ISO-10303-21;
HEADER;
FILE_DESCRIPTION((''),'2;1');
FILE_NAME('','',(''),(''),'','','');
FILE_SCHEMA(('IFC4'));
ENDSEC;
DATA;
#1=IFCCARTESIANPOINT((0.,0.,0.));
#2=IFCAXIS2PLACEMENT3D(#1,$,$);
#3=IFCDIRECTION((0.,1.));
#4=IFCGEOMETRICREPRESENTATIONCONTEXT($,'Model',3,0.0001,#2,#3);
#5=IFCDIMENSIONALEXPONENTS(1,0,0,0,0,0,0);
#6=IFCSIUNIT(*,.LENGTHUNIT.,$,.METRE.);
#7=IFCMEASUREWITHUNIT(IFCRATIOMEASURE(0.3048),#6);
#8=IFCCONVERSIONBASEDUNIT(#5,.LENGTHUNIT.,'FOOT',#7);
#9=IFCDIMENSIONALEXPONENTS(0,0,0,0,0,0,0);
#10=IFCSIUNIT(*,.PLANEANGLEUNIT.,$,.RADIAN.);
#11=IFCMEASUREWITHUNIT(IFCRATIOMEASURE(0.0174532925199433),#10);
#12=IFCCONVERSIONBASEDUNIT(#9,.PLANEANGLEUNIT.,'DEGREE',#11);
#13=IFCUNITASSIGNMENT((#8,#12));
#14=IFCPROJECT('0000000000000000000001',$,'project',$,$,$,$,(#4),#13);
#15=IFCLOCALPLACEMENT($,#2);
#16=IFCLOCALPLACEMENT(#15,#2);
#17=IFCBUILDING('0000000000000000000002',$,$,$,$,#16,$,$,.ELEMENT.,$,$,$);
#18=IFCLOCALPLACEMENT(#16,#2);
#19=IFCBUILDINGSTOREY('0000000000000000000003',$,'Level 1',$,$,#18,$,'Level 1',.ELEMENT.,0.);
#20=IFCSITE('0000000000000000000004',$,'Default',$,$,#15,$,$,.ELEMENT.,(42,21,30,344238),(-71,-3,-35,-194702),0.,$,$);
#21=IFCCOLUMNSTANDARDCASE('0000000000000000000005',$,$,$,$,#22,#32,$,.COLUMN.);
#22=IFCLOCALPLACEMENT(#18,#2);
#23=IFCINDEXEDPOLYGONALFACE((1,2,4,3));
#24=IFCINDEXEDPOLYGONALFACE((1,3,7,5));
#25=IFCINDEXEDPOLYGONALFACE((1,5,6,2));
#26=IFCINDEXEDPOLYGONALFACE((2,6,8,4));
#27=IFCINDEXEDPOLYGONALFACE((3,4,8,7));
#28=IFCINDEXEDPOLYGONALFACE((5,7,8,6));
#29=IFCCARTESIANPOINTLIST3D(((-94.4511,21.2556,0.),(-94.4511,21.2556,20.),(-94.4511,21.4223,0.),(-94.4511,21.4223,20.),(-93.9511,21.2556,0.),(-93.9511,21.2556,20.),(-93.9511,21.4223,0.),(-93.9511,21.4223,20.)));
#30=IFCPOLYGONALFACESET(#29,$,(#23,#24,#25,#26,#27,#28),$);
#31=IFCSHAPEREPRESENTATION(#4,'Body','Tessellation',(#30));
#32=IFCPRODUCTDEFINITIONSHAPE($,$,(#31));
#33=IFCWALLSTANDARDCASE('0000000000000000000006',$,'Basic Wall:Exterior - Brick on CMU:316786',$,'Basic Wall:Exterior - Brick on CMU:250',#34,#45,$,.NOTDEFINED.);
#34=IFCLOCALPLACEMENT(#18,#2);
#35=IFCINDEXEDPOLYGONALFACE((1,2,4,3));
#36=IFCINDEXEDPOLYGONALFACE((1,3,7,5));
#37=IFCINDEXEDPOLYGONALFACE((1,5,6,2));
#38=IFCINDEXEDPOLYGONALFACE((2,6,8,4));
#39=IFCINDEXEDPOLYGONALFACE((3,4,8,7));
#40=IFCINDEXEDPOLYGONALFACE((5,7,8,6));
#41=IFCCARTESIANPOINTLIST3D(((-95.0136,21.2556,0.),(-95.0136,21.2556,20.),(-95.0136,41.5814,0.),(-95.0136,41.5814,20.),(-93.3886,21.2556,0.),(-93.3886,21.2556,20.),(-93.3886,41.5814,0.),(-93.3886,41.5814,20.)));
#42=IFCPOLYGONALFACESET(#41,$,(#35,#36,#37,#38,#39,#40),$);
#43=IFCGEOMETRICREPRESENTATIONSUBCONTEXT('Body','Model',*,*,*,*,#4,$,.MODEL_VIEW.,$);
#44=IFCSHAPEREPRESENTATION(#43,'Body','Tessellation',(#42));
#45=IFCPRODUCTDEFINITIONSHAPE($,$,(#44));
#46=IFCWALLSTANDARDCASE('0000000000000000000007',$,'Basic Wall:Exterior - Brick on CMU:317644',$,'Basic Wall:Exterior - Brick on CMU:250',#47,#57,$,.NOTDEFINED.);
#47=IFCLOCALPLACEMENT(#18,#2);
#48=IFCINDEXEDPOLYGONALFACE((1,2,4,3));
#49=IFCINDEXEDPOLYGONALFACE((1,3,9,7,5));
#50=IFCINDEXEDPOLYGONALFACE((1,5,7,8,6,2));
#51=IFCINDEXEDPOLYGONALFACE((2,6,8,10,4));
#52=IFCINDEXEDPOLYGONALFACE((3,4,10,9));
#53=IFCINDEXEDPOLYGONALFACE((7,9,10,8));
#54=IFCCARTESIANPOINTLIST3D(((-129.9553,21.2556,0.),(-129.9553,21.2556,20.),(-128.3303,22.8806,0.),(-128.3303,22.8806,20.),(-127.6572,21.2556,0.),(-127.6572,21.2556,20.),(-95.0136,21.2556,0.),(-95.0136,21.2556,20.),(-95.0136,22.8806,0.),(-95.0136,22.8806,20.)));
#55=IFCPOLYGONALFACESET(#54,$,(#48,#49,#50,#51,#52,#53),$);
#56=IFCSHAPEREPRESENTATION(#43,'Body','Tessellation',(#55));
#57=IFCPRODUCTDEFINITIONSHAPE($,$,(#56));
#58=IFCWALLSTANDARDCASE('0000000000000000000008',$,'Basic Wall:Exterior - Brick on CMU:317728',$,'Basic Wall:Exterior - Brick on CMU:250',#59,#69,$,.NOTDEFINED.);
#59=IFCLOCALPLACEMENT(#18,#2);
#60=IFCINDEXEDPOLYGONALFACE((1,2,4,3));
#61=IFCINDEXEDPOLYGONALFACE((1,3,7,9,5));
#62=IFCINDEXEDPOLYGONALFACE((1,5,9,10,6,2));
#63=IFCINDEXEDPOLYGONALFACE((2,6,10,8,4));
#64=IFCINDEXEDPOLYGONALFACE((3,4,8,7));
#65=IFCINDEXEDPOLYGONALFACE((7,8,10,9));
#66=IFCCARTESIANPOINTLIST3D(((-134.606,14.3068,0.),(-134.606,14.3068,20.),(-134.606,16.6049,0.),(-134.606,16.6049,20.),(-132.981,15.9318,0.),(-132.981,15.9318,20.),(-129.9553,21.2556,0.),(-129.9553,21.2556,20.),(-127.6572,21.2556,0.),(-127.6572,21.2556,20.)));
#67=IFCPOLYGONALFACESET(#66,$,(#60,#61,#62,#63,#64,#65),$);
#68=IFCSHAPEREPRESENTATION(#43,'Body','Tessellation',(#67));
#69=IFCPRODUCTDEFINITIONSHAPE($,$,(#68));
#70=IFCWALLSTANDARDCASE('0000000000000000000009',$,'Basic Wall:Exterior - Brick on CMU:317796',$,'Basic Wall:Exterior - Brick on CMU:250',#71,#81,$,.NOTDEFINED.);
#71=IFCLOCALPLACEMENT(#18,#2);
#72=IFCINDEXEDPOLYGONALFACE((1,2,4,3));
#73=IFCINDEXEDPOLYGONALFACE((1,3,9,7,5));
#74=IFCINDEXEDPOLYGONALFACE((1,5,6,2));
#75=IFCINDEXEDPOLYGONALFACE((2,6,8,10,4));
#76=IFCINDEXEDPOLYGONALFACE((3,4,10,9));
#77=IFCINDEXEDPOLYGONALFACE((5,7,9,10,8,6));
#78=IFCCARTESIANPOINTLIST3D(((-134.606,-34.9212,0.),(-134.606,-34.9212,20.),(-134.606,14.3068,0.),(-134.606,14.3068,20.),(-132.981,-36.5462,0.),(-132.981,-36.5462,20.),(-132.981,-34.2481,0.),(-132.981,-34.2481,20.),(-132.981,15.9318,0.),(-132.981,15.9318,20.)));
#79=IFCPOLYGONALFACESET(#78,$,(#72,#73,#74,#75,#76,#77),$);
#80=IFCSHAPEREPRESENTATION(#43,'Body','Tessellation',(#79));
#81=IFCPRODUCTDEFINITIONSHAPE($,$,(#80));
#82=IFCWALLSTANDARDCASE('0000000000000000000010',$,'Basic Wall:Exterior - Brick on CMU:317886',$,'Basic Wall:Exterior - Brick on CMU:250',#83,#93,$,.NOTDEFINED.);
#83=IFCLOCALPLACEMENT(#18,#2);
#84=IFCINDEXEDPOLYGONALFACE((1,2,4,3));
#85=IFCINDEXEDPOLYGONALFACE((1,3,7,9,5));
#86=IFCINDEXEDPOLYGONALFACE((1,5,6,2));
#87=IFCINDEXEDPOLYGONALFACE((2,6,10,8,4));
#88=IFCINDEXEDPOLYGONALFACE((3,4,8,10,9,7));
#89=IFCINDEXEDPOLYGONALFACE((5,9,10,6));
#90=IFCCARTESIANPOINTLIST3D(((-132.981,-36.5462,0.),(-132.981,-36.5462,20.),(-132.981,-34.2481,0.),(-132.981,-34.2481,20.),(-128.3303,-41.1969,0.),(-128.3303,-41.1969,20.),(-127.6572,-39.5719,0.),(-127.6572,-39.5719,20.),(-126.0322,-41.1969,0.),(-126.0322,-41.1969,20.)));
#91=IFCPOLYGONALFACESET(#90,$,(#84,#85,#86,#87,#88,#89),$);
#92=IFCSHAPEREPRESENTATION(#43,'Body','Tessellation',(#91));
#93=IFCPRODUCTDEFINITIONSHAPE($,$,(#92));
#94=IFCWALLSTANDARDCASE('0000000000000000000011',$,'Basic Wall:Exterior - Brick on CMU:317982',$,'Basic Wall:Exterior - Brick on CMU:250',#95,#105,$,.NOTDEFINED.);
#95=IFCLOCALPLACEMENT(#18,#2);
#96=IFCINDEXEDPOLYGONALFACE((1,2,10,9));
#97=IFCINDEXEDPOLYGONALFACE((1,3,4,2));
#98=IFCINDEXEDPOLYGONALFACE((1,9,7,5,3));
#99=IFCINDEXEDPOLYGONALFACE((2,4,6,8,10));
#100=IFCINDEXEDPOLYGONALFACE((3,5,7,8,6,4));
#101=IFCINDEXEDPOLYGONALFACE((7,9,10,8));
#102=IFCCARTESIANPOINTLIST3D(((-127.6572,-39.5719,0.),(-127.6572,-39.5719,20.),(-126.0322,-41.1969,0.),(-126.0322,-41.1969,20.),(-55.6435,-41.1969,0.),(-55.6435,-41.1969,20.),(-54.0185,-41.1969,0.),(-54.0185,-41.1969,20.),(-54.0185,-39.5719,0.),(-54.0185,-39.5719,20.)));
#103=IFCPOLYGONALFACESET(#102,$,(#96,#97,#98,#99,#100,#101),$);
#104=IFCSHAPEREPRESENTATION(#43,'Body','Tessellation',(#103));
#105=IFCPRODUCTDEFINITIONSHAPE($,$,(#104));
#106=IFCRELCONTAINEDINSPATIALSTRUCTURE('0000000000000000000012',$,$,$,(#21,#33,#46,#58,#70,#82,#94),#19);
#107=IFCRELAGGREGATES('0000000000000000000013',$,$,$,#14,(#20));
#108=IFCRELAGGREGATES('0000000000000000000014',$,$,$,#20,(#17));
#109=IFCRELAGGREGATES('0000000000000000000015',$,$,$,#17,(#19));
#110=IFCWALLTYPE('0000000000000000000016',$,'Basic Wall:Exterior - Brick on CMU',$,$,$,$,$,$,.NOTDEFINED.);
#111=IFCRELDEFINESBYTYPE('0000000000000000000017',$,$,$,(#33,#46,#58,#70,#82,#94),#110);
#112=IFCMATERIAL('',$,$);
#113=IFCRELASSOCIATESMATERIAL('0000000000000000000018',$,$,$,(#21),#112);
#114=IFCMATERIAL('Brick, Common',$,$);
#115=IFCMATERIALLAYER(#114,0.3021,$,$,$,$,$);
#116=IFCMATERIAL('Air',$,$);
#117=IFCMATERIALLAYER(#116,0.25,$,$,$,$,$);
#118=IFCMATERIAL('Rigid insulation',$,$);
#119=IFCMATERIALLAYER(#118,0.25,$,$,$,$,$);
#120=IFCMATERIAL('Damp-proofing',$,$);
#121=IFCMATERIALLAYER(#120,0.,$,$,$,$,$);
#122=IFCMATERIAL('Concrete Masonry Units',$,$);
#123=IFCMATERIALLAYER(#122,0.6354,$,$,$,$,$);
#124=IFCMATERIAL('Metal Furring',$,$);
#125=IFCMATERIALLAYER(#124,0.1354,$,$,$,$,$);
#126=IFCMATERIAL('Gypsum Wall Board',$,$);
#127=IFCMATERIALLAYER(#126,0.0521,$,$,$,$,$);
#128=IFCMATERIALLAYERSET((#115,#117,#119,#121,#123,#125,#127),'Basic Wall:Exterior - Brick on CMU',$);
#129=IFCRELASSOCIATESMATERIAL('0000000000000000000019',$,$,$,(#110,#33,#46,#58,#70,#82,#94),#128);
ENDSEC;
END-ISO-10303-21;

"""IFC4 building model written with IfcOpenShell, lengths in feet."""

from ifc_helpers import new_model, entity, si_unit, converted_unit, direction, frame, frame_2d, origin, place, context, subcontext, project, spatial, polyline, rectangle, outline, extrude, material, layer, layer_set, layer_usage, type_object, element, save


model = new_model("IFC4")

# Units and contexts
model_context = context("Model", 3, precision=0.0001, world=origin(), true_north=direction((0.0, 1.0)))
body_context = subcontext(model_context, "Body", "Model", "MODEL_VIEW")
ifc_project = project(units=[converted_unit("LENGTHUNIT", "FOOT", entity("IfcRatioMeasure", 0.3048), si_unit("LENGTHUNIT", "METRE"), dimensions=[1, 0, 0, 0, 0, 0, 0]), converted_unit("PLANEANGLEUNIT", "DEGREE", entity("IfcRatioMeasure", 0.0174532925199433), si_unit("PLANEANGLEUNIT", "RADIAN"), dimensions=[0, 0, 0, 0, 0, 0, 0])], contexts=[model_context])

# Site, building, storey
site_placement = place(None, origin())
site = spatial("IfcSite", under=ifc_project, at=site_placement, Name="Default", CompositionType="ELEMENT", RefLatitude=(42, 21, 30, 344238), RefLongitude=(-71, -3, -35, -194702), RefElevation=0.0)
building_placement = place(site_placement, origin())
building = spatial("IfcBuilding", under=site, at=building_placement, CompositionType="ELEMENT")
storey_placement = place(building_placement, origin())
storey = spatial("IfcBuildingStorey", under=building, at=storey_placement, Name="Level 1", LongName="Level 1", CompositionType="ELEMENT", Elevation=0.0)

# Column
ifc_material_1 = material(Name="")
wall_1_placement = place(storey_placement, frame((-94.2011, 21.2556, 0.0), z_axis=(0.0, 0.0, 1.0), x_axis=(0.0, 1.0, 0.0)))
for number, where, z_axis, x_axis in (
    (1, (0.0833, 0.0, 0.0), (0.0, 0.0, 1.0), (1.0, 0.0, 0.0)),
):
    element("IfcColumnStandardCase", number, at=place(wall_1_placement, frame(where, z_axis=z_axis, x_axis=x_axis)), inside=storey, material=ifc_material_1, PredefinedType="COLUMN", context=model_context, shape_type="SweptSolid", body=[
        extrude(rectangle(XDim=0.1667, YDim=0.5), origin(), (0.0, 0.0, 1.0), 20.0),
    ])

# Walls
ifc_material_2 = material(Name="Brick, Common")
ifc_layer_1 = layer(ifc_material_2, 0.3021)
ifc_material_3 = material(Name="Air")
ifc_layer_2 = layer(ifc_material_3, 0.25)
ifc_material_4 = material(Name="Rigid insulation")
ifc_layer_3 = layer(ifc_material_4, 0.25)
ifc_material_5 = material(Name="Damp-proofing")
ifc_layer_4 = layer(ifc_material_5, 0.0)
ifc_material_6 = material(Name="Concrete Masonry Units")
ifc_layer_5 = layer(ifc_material_6, 0.6354)
ifc_material_7 = material(Name="Metal Furring")
ifc_layer_6 = layer(ifc_material_7, 0.1354)
ifc_material_8 = material(Name="Gypsum Wall Board")
ifc_layer_7 = layer(ifc_material_8, 0.0521)
ifc_layer_set = layer_set([ifc_layer_1, ifc_layer_2, ifc_layer_3, ifc_layer_4, ifc_layer_5, ifc_layer_6, ifc_layer_7], Name="Basic Wall:Exterior - Brick on CMU")
ifc_layer_usage_1 = layer_usage(ifc_layer_set, "AXIS2", "NEGATIVE", 0.8125)
wall_type = type_object("IfcWallType", Name="Basic Wall:Exterior - Brick on CMU", PredefinedType="NOTDEFINED", material=ifc_layer_set)
element("IfcWallStandardCase", 2, at=wall_1_placement, inside=storey, type_object=wall_type, material=ifc_layer_usage_1, Name="Basic Wall:Exterior - Brick on CMU:316786", ObjectType="Basic Wall:Exterior - Brick on CMU:250", PredefinedType="NOTDEFINED", context=body_context, shape_type="SweptSolid", body=[
    extrude(rectangle(XDim=20.3258, YDim=1.625, at=frame_2d((10.1629, 0.0), x_axis=(-1.0, 0.0))), origin(), (0.0, 0.0, 1.0), 20.0),
])
ifc_layer_usage_2 = layer_usage(ifc_layer_set, "AXIS2", "NEGATIVE", 0.8125)
wall_2_placement = place(storey_placement, frame((-95.0136, 22.0681, 0.0), z_axis=(0.0, 0.0, 1.0), x_axis=(-1.0, 0.0, 0.0)))
element("IfcWallStandardCase", 3, at=wall_2_placement, inside=storey, type_object=wall_type, material=ifc_layer_usage_2, Name="Basic Wall:Exterior - Brick on CMU:317644", ObjectType="Basic Wall:Exterior - Brick on CMU:250", PredefinedType="NOTDEFINED", context=body_context, shape_type="SweptSolid", body=[
    extrude(outline(polyline([(33.3167, -0.8125), (34.9417, 0.8125), (32.6436, 0.8125), (0.0, 0.8125), (0.0, -0.8125), (33.3167, -0.8125)])), origin(), (0.0, 0.0, 1.0), 20.0),
])
ifc_layer_usage_3 = layer_usage(ifc_layer_set, "AXIS2", "NEGATIVE", 0.8125)
wall_3_placement = place(storey_placement, frame((-128.2317, 21.8302, 0.0), z_axis=(0.0, 0.0, 1.0), x_axis=(-0.707107, -0.707107, 0.0)))
element("IfcWallStandardCase", 4, at=wall_3_placement, inside=storey, type_object=wall_type, material=ifc_layer_usage_3, Name="Basic Wall:Exterior - Brick on CMU:317728", ObjectType="Basic Wall:Exterior - Brick on CMU:250", PredefinedType="NOTDEFINED", context=body_context, shape_type="SweptSolid", body=[
    extrude(outline(polyline([(8.2021, -0.8125), (9.8271, 0.8125), (7.529, 0.8125), (0.0, 0.8125), (1.625, -0.8125), (8.2021, -0.8125)])), origin(), (0.0, 0.0, 1.0), 20.0),
])
ifc_layer_usage_4 = layer_usage(ifc_layer_set, "AXIS2", "NEGATIVE", 0.8125)
wall_4_placement = place(storey_placement, frame((-133.7935, 15.9318, 0.0), z_axis=(0.0, 0.0, 1.0), x_axis=(0.0, -1.0, 0.0)))
element("IfcWallStandardCase", 5, at=wall_4_placement, inside=storey, type_object=wall_type, material=ifc_layer_usage_4, Name="Basic Wall:Exterior - Brick on CMU:317796", ObjectType="Basic Wall:Exterior - Brick on CMU:250", PredefinedType="NOTDEFINED", context=body_context, shape_type="SweptSolid", body=[
    extrude(outline(polyline([(50.853, -0.8125), (52.478, 0.8125), (50.1799, 0.8125), (0.0, 0.8125), (1.625, -0.8125), (50.853, -0.8125)])), origin(), (0.0, 0.0, 1.0), 20.0),
])
ifc_layer_usage_5 = layer_usage(ifc_layer_set, "AXIS2", "NEGATIVE", 0.8125)
wall_5_placement = place(storey_placement, frame((-133.5555, -34.8226, 0.0), z_axis=(0.0, 0.0, 1.0), x_axis=(0.707107, -0.707107, 0.0)))
element("IfcWallStandardCase", 6, at=wall_5_placement, inside=storey, type_object=wall_type, material=ifc_layer_usage_5, Name="Basic Wall:Exterior - Brick on CMU:317886", ObjectType="Basic Wall:Exterior - Brick on CMU:250", PredefinedType="NOTDEFINED", context=body_context, shape_type="SweptSolid", body=[
    extrude(outline(polyline([(8.2021, -0.8125), (9.8271, 0.8125), (7.529, 0.8125), (0.0, 0.8125), (1.625, -0.8125), (8.2021, -0.8125)])), origin(), (0.0, 0.0, 1.0), 20.0),
])
ifc_layer_usage_6 = layer_usage(ifc_layer_set, "AXIS2", "NEGATIVE", 0.8125)
wall_6_placement = place(storey_placement, frame((-127.6572, -40.3844, 0.0)))
element("IfcWallStandardCase", 7, at=wall_6_placement, inside=storey, type_object=wall_type, material=ifc_layer_usage_6, Name="Basic Wall:Exterior - Brick on CMU:317982", ObjectType="Basic Wall:Exterior - Brick on CMU:250", PredefinedType="NOTDEFINED", context=body_context, shape_type="SweptSolid", body=[
    extrude(outline(polyline([(73.6387, -0.8125), (73.6387, 0.8125), (0.0, 0.8125), (1.625, -0.8125), (72.0137, -0.8125), (73.6387, -0.8125)])), origin(), (0.0, 0.0, 1.0), 20.0),
])

save(model, "model.ifc")
